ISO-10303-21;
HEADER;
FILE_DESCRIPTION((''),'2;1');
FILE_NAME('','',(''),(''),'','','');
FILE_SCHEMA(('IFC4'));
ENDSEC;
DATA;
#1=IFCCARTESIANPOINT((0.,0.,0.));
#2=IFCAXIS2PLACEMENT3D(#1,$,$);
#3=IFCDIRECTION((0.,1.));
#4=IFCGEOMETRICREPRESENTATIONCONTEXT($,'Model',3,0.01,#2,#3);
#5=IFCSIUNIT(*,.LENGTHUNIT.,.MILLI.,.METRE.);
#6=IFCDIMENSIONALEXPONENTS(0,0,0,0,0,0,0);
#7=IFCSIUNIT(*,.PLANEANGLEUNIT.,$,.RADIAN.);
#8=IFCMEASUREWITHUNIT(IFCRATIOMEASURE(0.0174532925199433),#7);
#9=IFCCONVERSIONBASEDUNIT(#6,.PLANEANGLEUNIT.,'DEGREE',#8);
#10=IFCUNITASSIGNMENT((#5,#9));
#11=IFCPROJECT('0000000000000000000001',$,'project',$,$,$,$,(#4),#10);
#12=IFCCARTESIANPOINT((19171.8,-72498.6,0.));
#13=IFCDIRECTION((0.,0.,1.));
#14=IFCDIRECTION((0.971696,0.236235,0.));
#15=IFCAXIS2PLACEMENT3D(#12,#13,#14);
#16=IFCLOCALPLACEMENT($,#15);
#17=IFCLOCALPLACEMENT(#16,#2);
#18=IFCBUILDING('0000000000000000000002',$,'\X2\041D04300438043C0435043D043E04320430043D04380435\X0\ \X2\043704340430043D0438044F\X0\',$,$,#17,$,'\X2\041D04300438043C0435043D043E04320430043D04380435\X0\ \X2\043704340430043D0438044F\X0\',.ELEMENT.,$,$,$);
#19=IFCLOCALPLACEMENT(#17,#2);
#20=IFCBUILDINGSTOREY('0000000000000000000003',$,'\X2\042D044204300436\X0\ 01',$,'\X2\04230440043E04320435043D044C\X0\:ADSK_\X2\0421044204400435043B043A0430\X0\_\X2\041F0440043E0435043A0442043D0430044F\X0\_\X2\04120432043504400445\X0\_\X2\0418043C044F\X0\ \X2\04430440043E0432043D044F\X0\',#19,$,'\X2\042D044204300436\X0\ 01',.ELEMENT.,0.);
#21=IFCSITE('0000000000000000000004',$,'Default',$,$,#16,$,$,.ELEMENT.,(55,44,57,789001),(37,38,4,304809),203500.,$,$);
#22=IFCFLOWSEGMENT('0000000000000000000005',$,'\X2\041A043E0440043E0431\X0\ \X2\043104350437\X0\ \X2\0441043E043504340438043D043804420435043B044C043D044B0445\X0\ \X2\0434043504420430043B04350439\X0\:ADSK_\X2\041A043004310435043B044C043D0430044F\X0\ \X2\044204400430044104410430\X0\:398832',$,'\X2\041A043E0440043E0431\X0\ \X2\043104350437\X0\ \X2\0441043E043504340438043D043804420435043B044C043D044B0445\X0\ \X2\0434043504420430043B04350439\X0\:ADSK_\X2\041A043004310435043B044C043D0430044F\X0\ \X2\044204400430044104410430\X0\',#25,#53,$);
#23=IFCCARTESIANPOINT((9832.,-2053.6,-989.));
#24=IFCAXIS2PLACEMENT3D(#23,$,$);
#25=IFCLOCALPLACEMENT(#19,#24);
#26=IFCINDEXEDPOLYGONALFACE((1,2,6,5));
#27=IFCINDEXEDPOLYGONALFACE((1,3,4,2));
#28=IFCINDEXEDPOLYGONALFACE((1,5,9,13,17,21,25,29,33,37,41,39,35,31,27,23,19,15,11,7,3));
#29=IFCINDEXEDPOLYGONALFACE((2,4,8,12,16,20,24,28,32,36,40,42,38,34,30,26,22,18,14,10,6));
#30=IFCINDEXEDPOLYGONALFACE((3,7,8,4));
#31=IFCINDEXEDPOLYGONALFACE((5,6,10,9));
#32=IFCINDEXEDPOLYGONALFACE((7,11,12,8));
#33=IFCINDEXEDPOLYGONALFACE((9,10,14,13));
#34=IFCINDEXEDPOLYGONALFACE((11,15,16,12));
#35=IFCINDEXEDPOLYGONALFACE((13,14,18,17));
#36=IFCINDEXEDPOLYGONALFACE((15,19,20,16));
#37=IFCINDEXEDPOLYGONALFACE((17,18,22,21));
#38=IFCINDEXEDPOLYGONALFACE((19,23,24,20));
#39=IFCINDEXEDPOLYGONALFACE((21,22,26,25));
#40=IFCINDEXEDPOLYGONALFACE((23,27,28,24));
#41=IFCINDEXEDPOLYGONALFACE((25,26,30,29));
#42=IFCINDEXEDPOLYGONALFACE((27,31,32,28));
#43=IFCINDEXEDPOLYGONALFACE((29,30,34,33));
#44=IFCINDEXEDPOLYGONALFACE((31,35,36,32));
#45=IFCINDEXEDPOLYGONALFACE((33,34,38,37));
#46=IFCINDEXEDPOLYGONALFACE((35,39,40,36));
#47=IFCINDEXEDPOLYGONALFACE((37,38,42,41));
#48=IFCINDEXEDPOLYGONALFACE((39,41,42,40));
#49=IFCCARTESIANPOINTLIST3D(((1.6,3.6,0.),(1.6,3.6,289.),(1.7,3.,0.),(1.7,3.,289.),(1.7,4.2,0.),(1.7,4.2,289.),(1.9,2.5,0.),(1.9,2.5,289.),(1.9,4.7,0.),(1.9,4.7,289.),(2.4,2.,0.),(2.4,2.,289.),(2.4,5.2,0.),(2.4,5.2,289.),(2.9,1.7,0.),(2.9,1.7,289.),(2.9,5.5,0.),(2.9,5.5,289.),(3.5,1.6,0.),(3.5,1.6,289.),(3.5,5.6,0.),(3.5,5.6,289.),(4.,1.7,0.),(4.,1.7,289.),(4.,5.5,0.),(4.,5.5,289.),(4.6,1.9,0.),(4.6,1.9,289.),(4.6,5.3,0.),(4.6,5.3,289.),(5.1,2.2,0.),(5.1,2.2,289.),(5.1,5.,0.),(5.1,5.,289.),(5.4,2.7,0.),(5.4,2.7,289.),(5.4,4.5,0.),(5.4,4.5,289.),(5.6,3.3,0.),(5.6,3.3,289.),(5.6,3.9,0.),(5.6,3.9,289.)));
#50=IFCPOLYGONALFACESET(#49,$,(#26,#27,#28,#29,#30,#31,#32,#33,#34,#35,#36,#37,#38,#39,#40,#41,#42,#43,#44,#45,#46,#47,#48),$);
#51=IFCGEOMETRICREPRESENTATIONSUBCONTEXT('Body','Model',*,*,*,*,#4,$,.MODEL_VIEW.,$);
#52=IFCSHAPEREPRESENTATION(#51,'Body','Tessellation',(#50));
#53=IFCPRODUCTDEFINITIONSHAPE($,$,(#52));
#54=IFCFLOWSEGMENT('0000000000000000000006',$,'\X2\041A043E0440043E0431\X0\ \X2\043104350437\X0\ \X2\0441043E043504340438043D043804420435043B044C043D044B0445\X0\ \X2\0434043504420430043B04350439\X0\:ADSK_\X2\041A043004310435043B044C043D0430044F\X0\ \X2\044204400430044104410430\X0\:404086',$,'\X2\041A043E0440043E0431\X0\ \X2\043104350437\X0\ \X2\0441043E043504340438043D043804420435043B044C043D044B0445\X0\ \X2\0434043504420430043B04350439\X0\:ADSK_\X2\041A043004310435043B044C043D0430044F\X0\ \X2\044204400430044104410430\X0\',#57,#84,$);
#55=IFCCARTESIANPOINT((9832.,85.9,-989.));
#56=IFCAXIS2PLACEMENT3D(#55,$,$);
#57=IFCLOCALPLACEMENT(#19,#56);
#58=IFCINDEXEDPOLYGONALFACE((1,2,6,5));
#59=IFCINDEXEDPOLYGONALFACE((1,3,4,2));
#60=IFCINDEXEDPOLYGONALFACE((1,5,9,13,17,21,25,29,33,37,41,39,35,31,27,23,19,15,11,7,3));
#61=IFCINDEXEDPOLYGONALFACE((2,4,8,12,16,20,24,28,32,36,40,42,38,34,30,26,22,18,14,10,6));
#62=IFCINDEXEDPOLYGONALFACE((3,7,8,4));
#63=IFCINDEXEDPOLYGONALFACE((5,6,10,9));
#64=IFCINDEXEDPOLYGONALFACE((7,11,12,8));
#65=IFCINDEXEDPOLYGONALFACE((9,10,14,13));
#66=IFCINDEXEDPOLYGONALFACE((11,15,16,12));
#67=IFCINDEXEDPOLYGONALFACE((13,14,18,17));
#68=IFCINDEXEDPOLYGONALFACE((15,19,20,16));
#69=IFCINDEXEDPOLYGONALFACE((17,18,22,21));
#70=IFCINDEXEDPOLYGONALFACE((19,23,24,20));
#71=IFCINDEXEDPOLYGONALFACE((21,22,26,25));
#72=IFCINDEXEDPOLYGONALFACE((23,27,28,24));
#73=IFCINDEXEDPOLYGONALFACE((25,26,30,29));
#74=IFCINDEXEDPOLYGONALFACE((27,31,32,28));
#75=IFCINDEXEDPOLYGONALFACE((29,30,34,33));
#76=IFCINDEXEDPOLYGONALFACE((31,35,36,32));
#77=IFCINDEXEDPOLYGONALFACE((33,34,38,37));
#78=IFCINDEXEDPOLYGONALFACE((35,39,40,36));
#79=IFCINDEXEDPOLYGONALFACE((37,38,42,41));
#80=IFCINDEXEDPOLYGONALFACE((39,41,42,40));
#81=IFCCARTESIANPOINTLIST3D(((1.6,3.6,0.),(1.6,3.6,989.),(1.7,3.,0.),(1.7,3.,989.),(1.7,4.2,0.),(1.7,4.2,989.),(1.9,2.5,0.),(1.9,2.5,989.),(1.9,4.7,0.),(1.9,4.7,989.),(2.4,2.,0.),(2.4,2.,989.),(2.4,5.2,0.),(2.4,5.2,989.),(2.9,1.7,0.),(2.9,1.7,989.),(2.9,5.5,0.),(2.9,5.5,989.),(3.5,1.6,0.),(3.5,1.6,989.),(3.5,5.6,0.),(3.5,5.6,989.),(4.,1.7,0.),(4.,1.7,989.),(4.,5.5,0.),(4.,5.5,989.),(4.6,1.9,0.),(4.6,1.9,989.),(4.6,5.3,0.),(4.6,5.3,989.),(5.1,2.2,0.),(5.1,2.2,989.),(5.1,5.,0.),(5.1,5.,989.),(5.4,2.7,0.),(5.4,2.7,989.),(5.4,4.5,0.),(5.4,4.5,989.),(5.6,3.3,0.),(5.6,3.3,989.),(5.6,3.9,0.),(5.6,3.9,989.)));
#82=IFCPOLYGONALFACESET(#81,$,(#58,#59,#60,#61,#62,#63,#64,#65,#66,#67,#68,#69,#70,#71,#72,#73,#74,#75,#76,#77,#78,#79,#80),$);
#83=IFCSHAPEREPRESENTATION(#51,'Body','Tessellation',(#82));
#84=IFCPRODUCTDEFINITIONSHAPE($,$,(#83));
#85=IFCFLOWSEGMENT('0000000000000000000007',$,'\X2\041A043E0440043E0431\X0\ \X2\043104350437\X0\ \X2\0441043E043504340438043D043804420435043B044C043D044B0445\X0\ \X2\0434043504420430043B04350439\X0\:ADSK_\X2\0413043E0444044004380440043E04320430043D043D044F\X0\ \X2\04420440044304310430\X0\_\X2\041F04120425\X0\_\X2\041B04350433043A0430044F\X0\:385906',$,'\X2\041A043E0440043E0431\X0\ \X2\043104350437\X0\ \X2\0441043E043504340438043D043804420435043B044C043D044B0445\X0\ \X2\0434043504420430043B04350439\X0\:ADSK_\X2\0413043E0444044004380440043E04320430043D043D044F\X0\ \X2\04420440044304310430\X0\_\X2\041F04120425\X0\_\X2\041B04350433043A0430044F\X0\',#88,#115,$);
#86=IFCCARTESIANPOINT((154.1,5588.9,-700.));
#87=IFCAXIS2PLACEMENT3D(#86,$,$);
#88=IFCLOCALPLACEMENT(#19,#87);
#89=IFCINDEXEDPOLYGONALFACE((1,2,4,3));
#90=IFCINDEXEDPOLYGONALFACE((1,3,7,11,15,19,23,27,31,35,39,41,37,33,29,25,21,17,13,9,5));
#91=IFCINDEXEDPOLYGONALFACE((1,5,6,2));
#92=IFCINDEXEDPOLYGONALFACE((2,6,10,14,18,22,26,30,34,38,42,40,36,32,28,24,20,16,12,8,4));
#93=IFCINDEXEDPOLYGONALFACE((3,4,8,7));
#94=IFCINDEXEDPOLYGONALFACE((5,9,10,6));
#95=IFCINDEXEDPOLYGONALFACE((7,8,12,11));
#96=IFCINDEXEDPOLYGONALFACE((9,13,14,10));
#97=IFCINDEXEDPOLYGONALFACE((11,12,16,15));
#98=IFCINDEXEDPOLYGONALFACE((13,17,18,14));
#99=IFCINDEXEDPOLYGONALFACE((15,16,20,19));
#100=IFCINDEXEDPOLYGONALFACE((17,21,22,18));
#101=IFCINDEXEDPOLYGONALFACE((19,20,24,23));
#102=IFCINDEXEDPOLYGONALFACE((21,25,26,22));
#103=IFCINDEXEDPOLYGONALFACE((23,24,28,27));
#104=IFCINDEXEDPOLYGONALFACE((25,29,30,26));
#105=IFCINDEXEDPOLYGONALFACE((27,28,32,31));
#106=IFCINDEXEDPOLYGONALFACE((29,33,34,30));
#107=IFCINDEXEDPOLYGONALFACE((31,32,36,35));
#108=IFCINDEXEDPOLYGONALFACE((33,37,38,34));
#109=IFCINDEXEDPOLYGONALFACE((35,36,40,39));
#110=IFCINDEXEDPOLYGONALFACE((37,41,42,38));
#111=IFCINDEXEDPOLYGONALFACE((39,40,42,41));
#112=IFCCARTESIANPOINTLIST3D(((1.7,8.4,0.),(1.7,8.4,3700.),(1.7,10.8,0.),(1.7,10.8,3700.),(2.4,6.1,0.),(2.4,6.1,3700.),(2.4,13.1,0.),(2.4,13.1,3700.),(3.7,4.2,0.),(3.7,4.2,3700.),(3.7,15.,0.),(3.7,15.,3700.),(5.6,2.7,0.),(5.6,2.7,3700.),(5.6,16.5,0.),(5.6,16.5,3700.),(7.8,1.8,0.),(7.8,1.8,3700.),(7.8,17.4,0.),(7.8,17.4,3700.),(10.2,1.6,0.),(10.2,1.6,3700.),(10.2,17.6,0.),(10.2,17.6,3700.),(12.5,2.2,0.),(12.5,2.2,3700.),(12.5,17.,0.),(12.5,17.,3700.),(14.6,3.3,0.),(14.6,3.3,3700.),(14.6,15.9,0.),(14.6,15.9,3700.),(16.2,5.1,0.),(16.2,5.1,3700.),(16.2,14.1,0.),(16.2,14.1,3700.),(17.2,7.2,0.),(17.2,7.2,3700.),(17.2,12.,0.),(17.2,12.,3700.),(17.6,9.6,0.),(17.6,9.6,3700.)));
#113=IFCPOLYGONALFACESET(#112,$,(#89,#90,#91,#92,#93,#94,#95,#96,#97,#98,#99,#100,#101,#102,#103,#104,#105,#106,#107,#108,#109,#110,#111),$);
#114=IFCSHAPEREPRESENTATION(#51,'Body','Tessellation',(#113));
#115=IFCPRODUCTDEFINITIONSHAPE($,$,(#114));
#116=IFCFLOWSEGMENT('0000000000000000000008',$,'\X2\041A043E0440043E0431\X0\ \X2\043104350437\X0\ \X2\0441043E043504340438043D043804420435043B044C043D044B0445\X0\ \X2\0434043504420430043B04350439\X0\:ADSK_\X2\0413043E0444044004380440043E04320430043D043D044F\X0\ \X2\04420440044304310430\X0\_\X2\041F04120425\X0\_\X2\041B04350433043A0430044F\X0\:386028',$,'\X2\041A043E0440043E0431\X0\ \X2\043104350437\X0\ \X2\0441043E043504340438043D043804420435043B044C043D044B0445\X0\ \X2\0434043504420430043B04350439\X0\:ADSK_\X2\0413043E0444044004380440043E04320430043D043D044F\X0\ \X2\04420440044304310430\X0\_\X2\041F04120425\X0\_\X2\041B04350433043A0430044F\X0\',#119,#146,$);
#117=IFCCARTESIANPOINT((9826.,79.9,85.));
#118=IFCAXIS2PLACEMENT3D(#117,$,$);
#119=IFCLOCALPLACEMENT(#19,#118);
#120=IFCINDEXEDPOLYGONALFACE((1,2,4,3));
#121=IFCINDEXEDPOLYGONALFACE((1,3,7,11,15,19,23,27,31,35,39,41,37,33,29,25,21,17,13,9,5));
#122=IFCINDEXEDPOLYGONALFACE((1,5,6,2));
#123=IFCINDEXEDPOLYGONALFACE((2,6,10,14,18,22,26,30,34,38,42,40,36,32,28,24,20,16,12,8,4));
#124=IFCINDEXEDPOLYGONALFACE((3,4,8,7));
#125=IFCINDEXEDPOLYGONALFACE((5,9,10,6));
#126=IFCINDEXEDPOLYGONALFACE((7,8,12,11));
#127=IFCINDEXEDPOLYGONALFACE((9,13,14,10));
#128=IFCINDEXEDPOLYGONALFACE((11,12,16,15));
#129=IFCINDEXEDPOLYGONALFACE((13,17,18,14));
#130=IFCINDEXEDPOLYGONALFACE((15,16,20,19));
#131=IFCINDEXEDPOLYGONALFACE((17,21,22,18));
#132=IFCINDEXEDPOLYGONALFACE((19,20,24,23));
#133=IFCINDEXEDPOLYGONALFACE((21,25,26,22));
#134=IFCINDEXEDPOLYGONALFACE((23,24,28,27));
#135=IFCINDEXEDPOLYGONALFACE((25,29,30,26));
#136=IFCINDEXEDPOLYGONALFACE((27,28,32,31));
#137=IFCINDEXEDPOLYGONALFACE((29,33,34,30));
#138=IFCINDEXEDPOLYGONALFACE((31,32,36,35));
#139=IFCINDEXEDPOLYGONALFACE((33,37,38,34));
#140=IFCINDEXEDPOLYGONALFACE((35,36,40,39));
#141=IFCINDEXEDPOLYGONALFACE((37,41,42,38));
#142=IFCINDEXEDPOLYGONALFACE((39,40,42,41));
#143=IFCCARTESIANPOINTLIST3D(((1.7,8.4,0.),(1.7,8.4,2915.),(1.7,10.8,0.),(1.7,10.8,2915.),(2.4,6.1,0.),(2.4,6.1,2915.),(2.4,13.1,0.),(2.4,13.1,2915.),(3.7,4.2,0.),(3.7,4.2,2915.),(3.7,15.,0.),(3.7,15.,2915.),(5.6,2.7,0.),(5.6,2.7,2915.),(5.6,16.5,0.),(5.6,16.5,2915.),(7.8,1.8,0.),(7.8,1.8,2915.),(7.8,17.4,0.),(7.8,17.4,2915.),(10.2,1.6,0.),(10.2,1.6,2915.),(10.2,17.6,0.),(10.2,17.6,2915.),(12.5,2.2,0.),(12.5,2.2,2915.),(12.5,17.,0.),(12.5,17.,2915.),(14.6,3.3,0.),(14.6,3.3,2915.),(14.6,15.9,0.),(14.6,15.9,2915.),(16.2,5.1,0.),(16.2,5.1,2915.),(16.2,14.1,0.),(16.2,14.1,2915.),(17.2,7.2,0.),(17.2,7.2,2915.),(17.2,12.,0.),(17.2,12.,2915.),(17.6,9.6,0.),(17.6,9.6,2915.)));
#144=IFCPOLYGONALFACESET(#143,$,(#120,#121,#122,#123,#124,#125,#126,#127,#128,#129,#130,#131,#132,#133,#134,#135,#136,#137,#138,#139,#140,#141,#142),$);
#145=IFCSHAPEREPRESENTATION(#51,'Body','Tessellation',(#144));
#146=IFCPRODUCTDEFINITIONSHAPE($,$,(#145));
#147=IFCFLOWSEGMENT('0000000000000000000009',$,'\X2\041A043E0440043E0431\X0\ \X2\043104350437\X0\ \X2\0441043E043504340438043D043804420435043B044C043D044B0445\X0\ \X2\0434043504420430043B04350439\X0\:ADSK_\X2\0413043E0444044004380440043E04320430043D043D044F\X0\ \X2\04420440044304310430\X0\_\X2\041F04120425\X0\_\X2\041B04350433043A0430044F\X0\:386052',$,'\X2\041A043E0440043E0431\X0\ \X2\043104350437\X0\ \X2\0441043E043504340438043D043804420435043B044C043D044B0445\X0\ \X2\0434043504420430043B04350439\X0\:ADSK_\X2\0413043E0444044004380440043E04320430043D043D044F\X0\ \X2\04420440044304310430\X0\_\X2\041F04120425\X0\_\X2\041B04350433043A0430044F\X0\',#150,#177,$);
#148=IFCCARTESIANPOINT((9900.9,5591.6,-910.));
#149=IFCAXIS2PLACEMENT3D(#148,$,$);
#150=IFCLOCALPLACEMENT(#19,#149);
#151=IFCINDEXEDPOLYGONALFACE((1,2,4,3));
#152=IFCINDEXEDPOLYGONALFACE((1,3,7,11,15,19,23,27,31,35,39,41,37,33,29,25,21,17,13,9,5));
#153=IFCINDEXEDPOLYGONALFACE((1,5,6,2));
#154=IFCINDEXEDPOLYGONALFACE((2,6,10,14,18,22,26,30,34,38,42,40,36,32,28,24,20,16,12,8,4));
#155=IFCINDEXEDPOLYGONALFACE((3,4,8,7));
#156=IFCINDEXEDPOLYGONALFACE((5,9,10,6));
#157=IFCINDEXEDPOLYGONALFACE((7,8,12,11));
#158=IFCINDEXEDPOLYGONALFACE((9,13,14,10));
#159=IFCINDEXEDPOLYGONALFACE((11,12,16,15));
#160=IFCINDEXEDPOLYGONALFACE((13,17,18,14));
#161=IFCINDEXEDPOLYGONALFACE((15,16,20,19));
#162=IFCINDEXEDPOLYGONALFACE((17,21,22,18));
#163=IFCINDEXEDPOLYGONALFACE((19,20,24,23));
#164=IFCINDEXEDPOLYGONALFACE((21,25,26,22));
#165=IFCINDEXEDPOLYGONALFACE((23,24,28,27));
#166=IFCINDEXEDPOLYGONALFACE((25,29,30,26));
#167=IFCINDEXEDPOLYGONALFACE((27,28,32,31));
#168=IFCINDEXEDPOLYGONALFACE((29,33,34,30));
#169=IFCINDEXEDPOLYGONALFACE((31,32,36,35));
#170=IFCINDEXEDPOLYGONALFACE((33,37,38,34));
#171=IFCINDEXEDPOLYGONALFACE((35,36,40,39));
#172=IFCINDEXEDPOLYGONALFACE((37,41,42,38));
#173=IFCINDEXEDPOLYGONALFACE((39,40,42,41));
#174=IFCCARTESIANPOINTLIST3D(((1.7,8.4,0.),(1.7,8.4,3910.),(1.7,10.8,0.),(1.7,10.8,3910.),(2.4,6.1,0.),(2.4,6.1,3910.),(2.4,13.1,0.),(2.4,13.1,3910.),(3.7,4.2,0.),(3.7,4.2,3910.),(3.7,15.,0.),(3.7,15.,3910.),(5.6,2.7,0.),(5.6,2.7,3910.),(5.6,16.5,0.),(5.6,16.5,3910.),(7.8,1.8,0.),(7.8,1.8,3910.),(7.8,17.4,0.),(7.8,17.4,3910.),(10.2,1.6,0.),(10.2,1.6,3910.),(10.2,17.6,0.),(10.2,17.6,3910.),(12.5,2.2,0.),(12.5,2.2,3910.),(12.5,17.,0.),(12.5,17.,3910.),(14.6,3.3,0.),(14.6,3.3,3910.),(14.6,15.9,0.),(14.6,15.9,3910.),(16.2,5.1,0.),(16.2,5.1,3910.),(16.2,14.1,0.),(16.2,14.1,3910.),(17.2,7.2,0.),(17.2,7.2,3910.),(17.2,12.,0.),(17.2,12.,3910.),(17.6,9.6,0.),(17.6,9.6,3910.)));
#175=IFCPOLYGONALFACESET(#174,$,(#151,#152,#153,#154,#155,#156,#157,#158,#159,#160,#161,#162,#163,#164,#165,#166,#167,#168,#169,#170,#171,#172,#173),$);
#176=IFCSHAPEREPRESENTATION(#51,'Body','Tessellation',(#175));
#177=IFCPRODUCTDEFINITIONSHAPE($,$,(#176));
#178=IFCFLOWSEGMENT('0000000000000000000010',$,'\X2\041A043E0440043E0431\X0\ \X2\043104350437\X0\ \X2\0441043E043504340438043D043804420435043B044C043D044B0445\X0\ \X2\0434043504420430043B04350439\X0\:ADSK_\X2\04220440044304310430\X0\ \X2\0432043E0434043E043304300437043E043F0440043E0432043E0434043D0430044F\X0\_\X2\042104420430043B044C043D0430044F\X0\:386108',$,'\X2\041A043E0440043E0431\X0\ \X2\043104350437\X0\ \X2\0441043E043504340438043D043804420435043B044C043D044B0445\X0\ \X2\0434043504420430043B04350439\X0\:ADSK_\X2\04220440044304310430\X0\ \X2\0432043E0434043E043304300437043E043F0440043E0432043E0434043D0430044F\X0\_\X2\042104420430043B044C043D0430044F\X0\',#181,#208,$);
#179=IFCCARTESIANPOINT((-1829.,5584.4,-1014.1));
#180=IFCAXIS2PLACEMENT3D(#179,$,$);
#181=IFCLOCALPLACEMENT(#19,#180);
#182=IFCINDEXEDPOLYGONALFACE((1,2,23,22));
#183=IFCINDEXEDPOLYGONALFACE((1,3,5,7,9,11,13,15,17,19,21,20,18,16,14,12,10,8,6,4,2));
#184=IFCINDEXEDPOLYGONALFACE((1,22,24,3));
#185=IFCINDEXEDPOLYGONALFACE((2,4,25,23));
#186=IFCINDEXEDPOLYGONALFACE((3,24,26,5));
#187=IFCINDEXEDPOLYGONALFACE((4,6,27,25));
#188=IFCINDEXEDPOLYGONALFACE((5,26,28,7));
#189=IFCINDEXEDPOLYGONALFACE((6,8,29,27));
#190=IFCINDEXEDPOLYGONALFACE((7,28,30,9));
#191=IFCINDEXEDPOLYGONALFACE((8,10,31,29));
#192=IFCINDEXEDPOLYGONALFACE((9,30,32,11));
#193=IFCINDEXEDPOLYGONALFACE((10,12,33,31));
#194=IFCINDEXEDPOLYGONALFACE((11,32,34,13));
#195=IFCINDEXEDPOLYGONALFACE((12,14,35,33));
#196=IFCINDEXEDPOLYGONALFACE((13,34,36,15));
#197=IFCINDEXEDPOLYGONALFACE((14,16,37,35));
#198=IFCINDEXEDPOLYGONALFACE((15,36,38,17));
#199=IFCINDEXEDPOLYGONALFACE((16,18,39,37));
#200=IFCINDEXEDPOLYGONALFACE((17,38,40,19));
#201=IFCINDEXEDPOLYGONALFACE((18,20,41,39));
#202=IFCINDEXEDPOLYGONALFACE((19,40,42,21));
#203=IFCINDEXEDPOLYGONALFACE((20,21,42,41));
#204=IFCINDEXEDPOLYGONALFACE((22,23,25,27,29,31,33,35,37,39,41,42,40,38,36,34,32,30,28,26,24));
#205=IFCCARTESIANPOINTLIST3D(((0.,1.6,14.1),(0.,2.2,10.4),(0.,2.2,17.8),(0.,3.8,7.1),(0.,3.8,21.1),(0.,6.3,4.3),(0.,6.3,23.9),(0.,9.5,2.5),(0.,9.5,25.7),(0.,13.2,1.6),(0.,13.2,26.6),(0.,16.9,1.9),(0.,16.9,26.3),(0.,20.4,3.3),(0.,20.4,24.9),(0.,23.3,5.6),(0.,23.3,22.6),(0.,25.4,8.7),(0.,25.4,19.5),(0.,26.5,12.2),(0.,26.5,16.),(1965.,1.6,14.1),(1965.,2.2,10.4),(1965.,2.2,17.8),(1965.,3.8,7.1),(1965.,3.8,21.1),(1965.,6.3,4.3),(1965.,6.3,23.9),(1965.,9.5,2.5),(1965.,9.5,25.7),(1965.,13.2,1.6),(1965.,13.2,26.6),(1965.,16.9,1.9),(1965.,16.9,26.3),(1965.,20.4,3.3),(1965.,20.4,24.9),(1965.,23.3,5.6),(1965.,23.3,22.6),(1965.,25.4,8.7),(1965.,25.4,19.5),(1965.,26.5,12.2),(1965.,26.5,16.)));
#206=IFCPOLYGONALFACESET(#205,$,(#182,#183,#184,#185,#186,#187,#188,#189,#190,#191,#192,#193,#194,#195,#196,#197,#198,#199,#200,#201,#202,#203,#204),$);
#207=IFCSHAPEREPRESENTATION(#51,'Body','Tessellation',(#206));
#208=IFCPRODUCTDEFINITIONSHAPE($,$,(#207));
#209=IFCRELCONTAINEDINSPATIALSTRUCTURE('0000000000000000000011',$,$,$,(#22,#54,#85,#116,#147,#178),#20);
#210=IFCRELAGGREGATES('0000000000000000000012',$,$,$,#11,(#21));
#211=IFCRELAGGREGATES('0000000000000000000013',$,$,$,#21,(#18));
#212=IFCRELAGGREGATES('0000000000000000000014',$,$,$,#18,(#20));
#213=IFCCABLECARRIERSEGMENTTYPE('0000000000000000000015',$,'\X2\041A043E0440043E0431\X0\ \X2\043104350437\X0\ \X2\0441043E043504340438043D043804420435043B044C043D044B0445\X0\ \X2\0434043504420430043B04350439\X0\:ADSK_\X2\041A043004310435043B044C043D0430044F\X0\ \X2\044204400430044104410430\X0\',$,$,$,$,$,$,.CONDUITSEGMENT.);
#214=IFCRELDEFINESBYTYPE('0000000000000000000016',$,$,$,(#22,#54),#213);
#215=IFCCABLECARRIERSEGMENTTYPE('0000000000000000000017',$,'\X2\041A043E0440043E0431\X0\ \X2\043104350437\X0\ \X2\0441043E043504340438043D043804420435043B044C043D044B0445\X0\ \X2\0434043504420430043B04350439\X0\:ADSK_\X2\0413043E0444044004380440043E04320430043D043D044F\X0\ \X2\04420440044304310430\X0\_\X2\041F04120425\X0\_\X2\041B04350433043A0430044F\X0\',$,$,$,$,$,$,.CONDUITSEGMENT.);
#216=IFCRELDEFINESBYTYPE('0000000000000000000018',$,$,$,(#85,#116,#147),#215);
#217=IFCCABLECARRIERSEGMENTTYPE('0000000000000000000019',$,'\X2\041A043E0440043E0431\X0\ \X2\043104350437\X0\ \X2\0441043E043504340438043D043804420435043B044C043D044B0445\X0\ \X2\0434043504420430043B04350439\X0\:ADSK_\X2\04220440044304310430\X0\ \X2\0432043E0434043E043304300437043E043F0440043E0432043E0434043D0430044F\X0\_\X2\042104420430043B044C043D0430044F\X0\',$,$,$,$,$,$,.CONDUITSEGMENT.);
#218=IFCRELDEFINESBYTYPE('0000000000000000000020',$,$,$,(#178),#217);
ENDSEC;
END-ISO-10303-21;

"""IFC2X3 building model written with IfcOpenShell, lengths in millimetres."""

from ifc_helpers import new_model, entity, si_unit, converted_unit, direction, frame, origin, origin_2d_with_axis, place, context, subcontext, project, spatial, circle, extrude, type_object, element, save


model = new_model("IFC2X3")

# Units and contexts
model_context = context("Model", 3, precision=0.01, world=origin(), true_north=direction((0.0, 1.0)))
body_context = subcontext(model_context, "Body", "Model", "MODEL_VIEW")
ifc_project = project(units=[si_unit("LENGTHUNIT", "METRE", prefix="MILLI"), converted_unit("PLANEANGLEUNIT", "DEGREE", entity("IfcRatioMeasure", 0.0174532925199433), si_unit("PLANEANGLEUNIT", "RADIAN"), dimensions=[0, 0, 0, 0, 0, 0, 0])], contexts=[model_context])

# Site, building, storey
site_placement = place(None, frame((19171.8, -72498.6, 0.0), z_axis=(0.0, 0.0, 1.0), x_axis=(0.971696, 0.236235, 0.0)))
site = spatial("IfcSite", under=ifc_project, at=site_placement, Name="Default", CompositionType="ELEMENT", RefLatitude=(55, 44, 57, 789001), RefLongitude=(37, 38, 4, 304809), RefElevation=203500.0)
building_placement = place(site_placement, origin())
building = spatial("IfcBuilding", under=site, at=building_placement, Name="Наименование здания", LongName="Наименование здания", CompositionType="ELEMENT")
storey_placement = place(building_placement, origin())
storey = spatial("IfcBuildingStorey", under=building, at=storey_placement, Name="Этаж 01", ObjectType="Уровень:ADSK_Стрелка_Проектная_Вверх_Имя уровня", LongName="Этаж 01", CompositionType="ELEMENT", Elevation=0.0)

# Flow segments
cable_carrier_segment_type_1 = type_object("IfcCableCarrierSegmentType", Name="Короб без соединительных деталей:ADSK_Кабельная трасса", PredefinedType="CONDUITSEGMENT")
flow_segment_1_placement = place(storey_placement, frame((9832.0, -2053.6, -989.0)))
element("IfcFlowSegment", 1, at=flow_segment_1_placement, inside=storey, type_object=cable_carrier_segment_type_1, Name="Короб без соединительных деталей:ADSK_Кабельная трасса:398832", ObjectType="Короб без соединительных деталей:ADSK_Кабельная трасса", context=body_context, shape_type="SweptSolid", body=[
    extrude(circle(Radius=2.0, at=origin_2d_with_axis()), frame((3.6, 3.6, 0.0), z_axis=(0.0, 0.0, 1.0), x_axis=(-1.0, 0.0, 0.0)), (0.0, 0.0, 1.0), 289.0),
])
flow_segment_2_placement = place(storey_placement, frame((9832.0, 85.9, -989.0)))
element("IfcFlowSegment", 2, at=flow_segment_2_placement, inside=storey, type_object=cable_carrier_segment_type_1, Name="Короб без соединительных деталей:ADSK_Кабельная трасса:404086", ObjectType="Короб без соединительных деталей:ADSK_Кабельная трасса", context=body_context, shape_type="SweptSolid", body=[
    extrude(circle(Radius=2.0, at=origin_2d_with_axis()), frame((3.6, 3.6, 0.0), z_axis=(0.0, 0.0, 1.0), x_axis=(-1.0, 0.0, 0.0)), (0.0, 0.0, 1.0), 989.0),
])
cable_carrier_segment_type_2 = type_object("IfcCableCarrierSegmentType", Name="Короб без соединительных деталей:ADSK_Гофрировання труба_ПВХ_Легкая", PredefinedType="CONDUITSEGMENT")
flow_segment_3_placement = place(storey_placement, frame((154.1, 5588.9, -700.0)))
element("IfcFlowSegment", 3, at=flow_segment_3_placement, inside=storey, type_object=cable_carrier_segment_type_2, Name="Короб без соединительных деталей:ADSK_Гофрировання труба_ПВХ_Легкая:385906", ObjectType="Короб без соединительных деталей:ADSK_Гофрировання труба_ПВХ_Легкая", context=body_context, shape_type="SweptSolid", body=[
    extrude(circle(Radius=8.0, at=origin_2d_with_axis()), frame((9.6, 9.6, 0.0)), (0.0, 0.0, 1.0), 3700.0),
])
flow_segment_4_placement = place(storey_placement, frame((9826.0, 79.9, 85.0)))
element("IfcFlowSegment", 4, at=flow_segment_4_placement, inside=storey, type_object=cable_carrier_segment_type_2, Name="Короб без соединительных деталей:ADSK_Гофрировання труба_ПВХ_Легкая:386028", ObjectType="Короб без соединительных деталей:ADSK_Гофрировання труба_ПВХ_Легкая", context=body_context, shape_type="SweptSolid", body=[
    extrude(circle(Radius=8.0, at=origin_2d_with_axis()), frame((9.6, 9.6, 0.0)), (0.0, 0.0, 1.0), 2915.0),
])
flow_segment_5_placement = place(storey_placement, frame((9900.9, 5591.6, -910.0)))
element("IfcFlowSegment", 5, at=flow_segment_5_placement, inside=storey, type_object=cable_carrier_segment_type_2, Name="Короб без соединительных деталей:ADSK_Гофрировання труба_ПВХ_Легкая:386052", ObjectType="Короб без соединительных деталей:ADSK_Гофрировання труба_ПВХ_Легкая", context=body_context, shape_type="SweptSolid", body=[
    extrude(circle(Radius=8.0, at=origin_2d_with_axis()), frame((9.6, 9.6, 0.0)), (0.0, 0.0, 1.0), 3910.0),
])
cable_carrier_segment_type_3 = type_object("IfcCableCarrierSegmentType", Name="Короб без соединительных деталей:ADSK_Труба водогазопроводная_Стальная", PredefinedType="CONDUITSEGMENT")
flow_segment_6_placement = place(storey_placement, frame((-1829.0, 5584.4, -1014.1)))
element("IfcFlowSegment", 6, at=flow_segment_6_placement, inside=storey, type_object=cable_carrier_segment_type_3, Name="Короб без соединительных деталей:ADSK_Труба водогазопроводная_Стальная:386108", ObjectType="Короб без соединительных деталей:ADSK_Труба водогазопроводная_Стальная", context=body_context, shape_type="SweptSolid", body=[
    extrude(circle(Radius=12.5, at=origin_2d_with_axis()), frame((0.0, 14.1, 14.1), z_axis=(1.0, 0.0, 0.0), x_axis=(0.0, -1.0, 0.0)), (0.0, 0.0, 1.0), 1965.0),
])

save(model, "model.ifc")
